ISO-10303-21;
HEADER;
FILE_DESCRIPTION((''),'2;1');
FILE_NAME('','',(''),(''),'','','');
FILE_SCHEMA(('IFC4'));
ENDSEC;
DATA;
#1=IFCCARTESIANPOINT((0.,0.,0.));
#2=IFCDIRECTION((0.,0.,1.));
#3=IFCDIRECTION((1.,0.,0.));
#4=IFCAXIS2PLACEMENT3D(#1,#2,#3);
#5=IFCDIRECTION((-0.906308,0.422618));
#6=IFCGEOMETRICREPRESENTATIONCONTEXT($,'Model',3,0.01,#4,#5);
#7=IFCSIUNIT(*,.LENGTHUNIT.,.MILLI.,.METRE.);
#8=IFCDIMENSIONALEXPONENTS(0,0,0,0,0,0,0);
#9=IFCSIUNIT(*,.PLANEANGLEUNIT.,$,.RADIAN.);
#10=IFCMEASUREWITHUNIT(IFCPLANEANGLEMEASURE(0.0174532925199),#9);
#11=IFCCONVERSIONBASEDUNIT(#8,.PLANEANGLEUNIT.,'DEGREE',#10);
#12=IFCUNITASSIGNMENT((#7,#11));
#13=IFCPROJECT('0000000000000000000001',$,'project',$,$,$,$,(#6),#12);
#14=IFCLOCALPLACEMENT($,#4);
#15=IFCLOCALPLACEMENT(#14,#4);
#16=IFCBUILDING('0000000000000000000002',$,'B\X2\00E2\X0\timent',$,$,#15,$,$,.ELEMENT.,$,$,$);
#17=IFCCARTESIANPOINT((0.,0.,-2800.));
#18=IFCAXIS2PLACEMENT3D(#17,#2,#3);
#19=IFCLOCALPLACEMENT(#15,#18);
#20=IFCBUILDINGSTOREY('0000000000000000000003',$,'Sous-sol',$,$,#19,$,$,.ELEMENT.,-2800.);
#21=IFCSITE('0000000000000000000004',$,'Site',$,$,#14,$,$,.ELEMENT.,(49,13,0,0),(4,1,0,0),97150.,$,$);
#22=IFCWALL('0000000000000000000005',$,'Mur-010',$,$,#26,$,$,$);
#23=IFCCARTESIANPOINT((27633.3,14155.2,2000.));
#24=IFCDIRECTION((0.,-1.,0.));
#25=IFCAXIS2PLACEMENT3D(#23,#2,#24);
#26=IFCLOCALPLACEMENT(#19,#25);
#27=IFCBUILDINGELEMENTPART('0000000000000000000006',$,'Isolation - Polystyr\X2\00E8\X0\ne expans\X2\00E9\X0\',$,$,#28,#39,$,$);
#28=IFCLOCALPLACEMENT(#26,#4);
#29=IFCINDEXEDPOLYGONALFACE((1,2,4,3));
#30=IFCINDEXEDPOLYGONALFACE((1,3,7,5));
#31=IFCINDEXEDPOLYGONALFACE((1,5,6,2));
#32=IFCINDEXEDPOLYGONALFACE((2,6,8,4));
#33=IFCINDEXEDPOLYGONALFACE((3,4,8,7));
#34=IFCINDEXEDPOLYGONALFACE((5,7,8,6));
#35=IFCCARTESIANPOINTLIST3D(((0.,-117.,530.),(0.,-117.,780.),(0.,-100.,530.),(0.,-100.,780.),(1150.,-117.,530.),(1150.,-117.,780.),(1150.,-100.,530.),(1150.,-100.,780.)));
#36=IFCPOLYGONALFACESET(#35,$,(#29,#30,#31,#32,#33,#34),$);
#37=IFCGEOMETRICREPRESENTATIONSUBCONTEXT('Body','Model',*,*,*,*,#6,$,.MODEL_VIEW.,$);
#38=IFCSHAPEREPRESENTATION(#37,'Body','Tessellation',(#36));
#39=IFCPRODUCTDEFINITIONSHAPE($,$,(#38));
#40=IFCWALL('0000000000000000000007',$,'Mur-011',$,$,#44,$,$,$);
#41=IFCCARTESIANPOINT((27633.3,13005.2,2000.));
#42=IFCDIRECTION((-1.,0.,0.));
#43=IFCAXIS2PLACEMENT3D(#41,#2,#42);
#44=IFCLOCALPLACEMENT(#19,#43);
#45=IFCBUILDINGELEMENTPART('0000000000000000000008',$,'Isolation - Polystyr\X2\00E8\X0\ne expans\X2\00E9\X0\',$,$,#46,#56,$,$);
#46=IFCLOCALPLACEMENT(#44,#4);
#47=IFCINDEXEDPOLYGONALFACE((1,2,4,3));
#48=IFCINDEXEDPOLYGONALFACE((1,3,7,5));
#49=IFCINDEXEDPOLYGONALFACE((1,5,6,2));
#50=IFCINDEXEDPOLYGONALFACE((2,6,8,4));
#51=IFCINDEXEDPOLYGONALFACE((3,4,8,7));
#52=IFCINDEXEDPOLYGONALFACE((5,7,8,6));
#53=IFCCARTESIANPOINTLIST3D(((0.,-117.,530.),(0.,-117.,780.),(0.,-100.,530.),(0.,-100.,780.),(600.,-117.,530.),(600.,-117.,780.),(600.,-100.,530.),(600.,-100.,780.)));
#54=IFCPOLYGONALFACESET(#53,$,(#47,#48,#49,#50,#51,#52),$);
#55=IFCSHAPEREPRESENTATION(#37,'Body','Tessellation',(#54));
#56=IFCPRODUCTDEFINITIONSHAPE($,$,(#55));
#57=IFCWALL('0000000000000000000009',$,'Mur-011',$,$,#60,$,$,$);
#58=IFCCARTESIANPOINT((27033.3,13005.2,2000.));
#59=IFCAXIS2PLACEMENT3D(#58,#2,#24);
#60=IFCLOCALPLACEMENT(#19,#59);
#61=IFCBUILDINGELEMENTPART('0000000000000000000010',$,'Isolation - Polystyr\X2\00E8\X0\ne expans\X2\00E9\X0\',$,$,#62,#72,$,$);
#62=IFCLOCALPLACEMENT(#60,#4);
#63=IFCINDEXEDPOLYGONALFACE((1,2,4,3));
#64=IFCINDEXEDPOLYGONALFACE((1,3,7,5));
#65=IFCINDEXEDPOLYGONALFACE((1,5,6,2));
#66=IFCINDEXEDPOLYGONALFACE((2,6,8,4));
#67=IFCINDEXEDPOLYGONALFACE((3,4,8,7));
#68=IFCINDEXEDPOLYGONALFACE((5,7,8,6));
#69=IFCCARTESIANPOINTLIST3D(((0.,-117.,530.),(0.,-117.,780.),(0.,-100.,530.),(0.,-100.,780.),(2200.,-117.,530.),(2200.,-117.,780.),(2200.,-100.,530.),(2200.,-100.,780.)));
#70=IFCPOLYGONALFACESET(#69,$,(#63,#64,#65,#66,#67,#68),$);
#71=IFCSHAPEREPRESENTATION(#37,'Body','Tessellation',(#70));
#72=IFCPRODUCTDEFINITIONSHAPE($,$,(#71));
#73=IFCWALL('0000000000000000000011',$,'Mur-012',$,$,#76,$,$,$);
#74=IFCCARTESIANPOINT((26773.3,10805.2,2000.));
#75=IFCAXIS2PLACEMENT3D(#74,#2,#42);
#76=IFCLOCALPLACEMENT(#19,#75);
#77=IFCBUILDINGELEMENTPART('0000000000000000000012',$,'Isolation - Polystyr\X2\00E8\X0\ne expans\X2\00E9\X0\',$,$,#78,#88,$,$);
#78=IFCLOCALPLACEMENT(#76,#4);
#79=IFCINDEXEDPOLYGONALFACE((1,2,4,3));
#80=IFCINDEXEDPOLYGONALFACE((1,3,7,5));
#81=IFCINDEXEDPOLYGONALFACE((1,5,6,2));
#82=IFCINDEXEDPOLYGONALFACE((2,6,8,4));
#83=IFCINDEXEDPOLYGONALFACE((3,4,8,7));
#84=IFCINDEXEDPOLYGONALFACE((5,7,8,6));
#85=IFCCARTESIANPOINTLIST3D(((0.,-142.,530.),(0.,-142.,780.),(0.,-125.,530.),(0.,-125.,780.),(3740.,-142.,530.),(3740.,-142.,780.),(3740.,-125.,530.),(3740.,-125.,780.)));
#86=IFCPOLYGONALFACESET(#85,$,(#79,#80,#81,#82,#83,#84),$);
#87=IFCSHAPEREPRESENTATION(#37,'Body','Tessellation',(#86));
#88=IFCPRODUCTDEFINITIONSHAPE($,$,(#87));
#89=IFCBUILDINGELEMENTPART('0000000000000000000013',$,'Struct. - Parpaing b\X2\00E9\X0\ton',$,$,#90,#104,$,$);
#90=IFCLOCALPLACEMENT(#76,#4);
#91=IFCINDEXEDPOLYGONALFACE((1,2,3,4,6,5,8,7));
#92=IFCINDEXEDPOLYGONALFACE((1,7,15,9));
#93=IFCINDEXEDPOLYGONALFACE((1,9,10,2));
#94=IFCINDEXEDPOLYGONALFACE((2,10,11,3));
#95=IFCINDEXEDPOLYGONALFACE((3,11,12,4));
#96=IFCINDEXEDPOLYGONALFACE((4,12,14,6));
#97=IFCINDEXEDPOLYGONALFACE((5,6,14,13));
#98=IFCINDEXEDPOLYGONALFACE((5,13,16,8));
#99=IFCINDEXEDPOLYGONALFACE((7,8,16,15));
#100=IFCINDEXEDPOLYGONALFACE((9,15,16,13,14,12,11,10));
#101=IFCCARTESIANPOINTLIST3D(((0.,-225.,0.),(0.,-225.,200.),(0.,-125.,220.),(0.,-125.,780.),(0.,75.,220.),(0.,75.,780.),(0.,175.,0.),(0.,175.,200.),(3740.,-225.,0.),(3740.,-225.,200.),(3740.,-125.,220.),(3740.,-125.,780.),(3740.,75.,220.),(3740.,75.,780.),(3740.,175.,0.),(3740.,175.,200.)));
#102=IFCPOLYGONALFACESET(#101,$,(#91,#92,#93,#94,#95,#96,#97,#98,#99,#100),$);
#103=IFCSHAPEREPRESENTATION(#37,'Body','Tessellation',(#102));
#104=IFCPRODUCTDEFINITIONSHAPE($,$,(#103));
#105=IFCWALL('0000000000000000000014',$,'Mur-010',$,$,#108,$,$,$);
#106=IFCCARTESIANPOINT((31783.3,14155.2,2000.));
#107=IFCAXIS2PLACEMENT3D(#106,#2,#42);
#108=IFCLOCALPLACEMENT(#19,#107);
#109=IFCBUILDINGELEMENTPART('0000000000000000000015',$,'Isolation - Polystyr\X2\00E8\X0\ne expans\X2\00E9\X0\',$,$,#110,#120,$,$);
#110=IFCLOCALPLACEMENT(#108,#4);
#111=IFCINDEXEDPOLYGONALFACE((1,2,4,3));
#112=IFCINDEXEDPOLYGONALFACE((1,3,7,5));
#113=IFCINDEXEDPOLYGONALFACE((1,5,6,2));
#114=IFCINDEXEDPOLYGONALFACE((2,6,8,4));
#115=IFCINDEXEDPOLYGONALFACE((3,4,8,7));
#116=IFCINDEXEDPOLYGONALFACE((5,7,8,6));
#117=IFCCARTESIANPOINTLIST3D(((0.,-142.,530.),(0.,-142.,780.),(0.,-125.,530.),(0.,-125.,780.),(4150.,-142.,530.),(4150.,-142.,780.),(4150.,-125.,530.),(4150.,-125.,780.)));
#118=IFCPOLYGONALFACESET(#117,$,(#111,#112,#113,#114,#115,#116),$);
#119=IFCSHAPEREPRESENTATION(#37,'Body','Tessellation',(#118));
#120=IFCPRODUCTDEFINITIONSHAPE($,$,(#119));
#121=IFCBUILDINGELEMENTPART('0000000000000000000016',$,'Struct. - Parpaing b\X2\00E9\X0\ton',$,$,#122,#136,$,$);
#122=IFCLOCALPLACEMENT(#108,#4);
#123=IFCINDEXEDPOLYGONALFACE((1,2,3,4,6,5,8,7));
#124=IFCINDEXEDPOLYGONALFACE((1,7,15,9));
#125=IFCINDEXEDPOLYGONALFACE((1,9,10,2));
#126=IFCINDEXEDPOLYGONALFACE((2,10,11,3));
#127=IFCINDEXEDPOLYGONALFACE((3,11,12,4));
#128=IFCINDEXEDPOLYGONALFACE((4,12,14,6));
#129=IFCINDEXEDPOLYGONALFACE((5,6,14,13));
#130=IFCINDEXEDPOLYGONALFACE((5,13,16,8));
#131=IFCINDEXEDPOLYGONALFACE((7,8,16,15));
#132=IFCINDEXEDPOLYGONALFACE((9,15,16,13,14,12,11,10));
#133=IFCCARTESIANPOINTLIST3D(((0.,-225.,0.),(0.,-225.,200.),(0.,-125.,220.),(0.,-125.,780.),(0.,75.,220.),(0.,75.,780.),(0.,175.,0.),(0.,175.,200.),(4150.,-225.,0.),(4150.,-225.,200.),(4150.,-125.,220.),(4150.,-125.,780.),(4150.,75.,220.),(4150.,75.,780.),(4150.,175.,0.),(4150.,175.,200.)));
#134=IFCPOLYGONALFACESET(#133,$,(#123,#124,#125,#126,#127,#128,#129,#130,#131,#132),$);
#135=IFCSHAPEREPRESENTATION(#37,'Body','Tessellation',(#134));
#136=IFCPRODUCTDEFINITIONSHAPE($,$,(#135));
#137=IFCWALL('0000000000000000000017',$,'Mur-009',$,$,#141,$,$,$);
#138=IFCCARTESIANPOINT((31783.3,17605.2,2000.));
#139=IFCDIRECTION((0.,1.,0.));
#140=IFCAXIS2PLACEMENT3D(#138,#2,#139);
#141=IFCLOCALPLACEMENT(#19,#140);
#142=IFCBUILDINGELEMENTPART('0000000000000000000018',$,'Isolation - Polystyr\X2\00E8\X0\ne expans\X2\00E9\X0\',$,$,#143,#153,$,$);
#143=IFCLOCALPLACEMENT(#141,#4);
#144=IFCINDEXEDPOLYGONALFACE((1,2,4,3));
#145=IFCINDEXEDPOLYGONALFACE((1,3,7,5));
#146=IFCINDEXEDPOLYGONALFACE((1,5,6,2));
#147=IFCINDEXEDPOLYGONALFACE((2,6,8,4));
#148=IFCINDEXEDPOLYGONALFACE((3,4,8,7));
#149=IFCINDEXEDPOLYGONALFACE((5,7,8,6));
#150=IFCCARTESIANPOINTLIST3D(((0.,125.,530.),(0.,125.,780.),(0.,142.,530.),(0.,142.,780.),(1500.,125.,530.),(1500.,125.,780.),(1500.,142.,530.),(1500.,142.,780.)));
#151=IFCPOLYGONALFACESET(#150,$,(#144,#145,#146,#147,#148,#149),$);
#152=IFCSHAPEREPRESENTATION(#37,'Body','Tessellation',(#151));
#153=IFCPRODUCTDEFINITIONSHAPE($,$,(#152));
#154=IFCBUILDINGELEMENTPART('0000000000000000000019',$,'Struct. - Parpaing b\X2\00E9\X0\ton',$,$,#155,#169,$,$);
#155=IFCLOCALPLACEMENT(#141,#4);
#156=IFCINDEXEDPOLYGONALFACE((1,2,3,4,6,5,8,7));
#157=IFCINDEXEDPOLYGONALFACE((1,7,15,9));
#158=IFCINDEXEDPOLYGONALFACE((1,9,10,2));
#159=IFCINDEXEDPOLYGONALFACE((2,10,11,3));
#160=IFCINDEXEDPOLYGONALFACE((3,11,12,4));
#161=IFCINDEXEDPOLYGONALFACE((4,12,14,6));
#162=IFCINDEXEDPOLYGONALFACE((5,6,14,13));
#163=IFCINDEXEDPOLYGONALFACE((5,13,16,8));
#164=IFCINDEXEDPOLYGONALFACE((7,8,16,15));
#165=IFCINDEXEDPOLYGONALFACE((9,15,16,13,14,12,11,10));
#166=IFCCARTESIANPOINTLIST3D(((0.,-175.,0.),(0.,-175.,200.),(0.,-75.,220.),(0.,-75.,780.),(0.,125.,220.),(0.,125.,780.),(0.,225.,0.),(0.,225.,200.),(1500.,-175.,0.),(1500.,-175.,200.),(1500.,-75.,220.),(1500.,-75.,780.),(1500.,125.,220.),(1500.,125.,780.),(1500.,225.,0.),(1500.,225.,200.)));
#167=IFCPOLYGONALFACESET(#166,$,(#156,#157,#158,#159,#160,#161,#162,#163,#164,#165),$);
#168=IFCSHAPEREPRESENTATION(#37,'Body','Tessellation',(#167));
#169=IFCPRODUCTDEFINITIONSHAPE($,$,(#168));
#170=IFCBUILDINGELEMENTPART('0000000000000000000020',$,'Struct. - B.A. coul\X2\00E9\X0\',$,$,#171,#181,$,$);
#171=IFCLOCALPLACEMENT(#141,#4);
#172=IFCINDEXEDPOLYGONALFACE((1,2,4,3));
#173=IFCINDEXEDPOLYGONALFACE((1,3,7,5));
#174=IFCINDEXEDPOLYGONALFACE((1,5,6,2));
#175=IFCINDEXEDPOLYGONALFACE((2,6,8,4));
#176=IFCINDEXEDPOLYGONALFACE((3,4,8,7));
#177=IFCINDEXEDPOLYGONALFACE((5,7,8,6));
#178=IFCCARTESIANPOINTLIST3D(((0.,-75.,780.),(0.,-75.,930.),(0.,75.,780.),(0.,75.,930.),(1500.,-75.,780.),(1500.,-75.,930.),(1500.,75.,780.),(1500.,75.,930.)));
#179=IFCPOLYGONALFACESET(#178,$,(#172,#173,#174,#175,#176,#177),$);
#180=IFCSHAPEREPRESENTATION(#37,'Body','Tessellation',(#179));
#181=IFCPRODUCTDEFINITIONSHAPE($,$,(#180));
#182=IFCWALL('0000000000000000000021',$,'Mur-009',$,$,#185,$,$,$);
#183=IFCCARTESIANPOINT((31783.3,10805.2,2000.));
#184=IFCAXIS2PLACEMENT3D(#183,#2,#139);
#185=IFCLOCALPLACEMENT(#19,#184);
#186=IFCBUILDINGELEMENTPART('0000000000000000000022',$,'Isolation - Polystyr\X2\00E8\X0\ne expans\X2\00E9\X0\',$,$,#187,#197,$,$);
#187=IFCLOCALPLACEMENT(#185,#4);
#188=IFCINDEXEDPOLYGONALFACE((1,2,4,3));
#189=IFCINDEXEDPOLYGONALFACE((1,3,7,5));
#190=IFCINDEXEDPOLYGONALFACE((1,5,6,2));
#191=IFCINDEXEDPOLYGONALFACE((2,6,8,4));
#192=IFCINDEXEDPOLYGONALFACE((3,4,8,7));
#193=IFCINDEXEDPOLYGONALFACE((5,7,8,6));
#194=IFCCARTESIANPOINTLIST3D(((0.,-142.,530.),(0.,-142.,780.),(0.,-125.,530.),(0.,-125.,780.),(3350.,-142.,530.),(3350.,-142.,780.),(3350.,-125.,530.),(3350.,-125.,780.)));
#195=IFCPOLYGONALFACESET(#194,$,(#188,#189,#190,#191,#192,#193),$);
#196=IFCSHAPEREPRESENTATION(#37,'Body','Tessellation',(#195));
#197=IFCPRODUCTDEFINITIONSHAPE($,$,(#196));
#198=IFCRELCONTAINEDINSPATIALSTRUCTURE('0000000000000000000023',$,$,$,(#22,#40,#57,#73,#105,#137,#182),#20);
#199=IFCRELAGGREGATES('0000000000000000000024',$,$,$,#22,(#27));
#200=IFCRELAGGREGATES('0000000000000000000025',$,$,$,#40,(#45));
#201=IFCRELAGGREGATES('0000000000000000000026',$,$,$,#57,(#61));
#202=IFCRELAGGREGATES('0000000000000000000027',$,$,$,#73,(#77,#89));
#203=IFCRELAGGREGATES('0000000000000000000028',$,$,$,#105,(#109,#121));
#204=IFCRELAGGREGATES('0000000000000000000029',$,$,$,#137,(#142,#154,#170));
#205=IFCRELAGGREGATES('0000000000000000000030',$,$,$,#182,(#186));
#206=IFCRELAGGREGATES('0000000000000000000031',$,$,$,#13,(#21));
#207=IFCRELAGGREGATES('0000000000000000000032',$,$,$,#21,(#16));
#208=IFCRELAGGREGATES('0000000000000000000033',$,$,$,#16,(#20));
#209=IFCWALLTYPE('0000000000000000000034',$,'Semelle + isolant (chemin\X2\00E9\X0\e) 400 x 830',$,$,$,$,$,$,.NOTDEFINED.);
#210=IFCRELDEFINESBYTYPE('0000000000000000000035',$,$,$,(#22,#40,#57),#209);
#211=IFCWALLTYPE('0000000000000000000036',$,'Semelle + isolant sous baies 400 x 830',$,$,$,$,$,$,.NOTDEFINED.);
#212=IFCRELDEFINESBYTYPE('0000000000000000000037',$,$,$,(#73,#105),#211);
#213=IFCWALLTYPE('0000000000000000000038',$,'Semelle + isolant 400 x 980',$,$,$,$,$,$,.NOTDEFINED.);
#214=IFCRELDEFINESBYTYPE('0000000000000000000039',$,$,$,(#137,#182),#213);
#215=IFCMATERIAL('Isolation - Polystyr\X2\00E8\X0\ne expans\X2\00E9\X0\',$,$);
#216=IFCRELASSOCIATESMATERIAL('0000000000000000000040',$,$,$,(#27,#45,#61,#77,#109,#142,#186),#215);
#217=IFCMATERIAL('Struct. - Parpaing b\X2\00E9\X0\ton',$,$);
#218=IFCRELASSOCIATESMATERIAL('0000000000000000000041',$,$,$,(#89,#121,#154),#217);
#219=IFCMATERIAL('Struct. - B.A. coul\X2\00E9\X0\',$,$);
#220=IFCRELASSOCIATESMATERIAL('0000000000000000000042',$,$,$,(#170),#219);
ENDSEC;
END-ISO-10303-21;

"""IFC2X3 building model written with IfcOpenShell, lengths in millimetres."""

from ifc_helpers import new_model, entity, si_unit, converted_unit, direction, frame, origin_with_axes, place, context, subcontext, project, spatial, polyline, outline, extrude, material, type_object, element, aggregate, save


model = new_model("IFC2X3")

# Units and contexts
model_context = context("Model", 3, precision=0.01, world=origin_with_axes(), true_north=direction((-0.906308, 0.422618)))
body_context = subcontext(model_context, "Body", "Model", "MODEL_VIEW")
ifc_project = project(units=[si_unit("LENGTHUNIT", "METRE", prefix="MILLI"), converted_unit("PLANEANGLEUNIT", "DEGREE", entity("IfcPlaneAngleMeasure", 0.0174532925199), si_unit("PLANEANGLEUNIT", "RADIAN"), dimensions=[0, 0, 0, 0, 0, 0, 0])], contexts=[model_context])

# Site, building, storey
site_placement = place(None, origin_with_axes())
site = spatial("IfcSite", under=ifc_project, at=site_placement, Name="Site", CompositionType="ELEMENT", RefLatitude=(49, 13, 0, 0), RefLongitude=(4, 1, 0, 0), RefElevation=97150.0)
building_placement = place(site_placement, origin_with_axes())
building = spatial("IfcBuilding", under=site, at=building_placement, Name="Bâtiment", CompositionType="ELEMENT")
storey_placement = place(building_placement, frame((0.0, 0.0, -2800.0), z_axis=(0.0, 0.0, 1.0), x_axis=(1.0, 0.0, 0.0)))
storey = spatial("IfcBuildingStorey", under=building, at=storey_placement, Name="Sous-sol", CompositionType="ELEMENT", Elevation=-2800.0)

# Walls, building element parts
ifc_material_1 = material(Name="Struct. - Parpaing béton")
wall_type_1 = type_object("IfcWallType", Name="Semelle + isolant (cheminée) 400 x 830", PredefinedType="NOTDEFINED")
wall_1_placement = place(storey_placement, frame((27633.3, 14155.2, 2000.0), z_axis=(0.0, 0.0, 1.0), x_axis=(0.0, -1.0, 0.0)))
wall_1 = element("IfcWall", 1, at=wall_1_placement, inside=storey, type_object=wall_type_1, Name="Mur-010")
ifc_material_2 = material(Name="Isolation - Polystyrène expansé")
building_element_part_1_placement = place(wall_1_placement, origin_with_axes())
building_element_part_1 = element("IfcBuildingElementPart", 2, at=building_element_part_1_placement, material=ifc_material_2, Name="Isolation - Polystyrène expansé", context=body_context, shape_type="SweptSolid", body=[
    extrude(outline(polyline([(100.0, 780.0), (100.0, 530.0), (117.0, 530.0), (117.0, 780.0), (100.0, 780.0)])), frame((0.0, 0.0, 0.0), z_axis=(-1.0, 0.0, 0.0), x_axis=(0.0, -1.0, 0.0)), (0.0, 0.0, -1.0), 1150.0),
])
aggregate(wall_1, [building_element_part_1])
wall_2_placement = place(storey_placement, frame((27633.3, 13005.2, 2000.0), z_axis=(0.0, 0.0, 1.0), x_axis=(-1.0, 0.0, 0.0)))
wall_2 = element("IfcWall", 3, at=wall_2_placement, inside=storey, type_object=wall_type_1, Name="Mur-011")
building_element_part_2_placement = place(wall_2_placement, origin_with_axes())
building_element_part_2 = element("IfcBuildingElementPart", 4, at=building_element_part_2_placement, material=ifc_material_2, Name="Isolation - Polystyrène expansé", context=body_context, shape_type="SweptSolid", body=[
    extrude(outline(polyline([(100.0, 780.0), (100.0, 530.0), (117.0, 530.0), (117.0, 780.0), (100.0, 780.0)])), frame((0.0, 0.0, 0.0), z_axis=(-1.0, 0.0, 0.0), x_axis=(0.0, -1.0, 0.0)), (0.0, 0.0, -1.0), 600.0),
])
aggregate(wall_2, [building_element_part_2])
wall_3_placement = place(storey_placement, frame((27033.3, 13005.2, 2000.0), z_axis=(0.0, 0.0, 1.0), x_axis=(0.0, -1.0, 0.0)))
wall_3 = element("IfcWall", 5, at=wall_3_placement, inside=storey, type_object=wall_type_1, Name="Mur-011")
building_element_part_3_placement = place(wall_3_placement, origin_with_axes())
building_element_part_3 = element("IfcBuildingElementPart", 6, at=building_element_part_3_placement, material=ifc_material_2, Name="Isolation - Polystyrène expansé", context=body_context, shape_type="SweptSolid", body=[
    extrude(outline(polyline([(100.0, 780.0), (100.0, 530.0), (117.0, 530.0), (117.0, 780.0), (100.0, 780.0)])), frame((0.0, 0.0, 0.0), z_axis=(-1.0, 0.0, 0.0), x_axis=(0.0, -1.0, 0.0)), (0.0, 0.0, -1.0), 2200.0),
])
aggregate(wall_3, [building_element_part_3])
wall_type_2 = type_object("IfcWallType", Name="Semelle + isolant sous baies 400 x 830", PredefinedType="NOTDEFINED")
wall_4_placement = place(storey_placement, frame((26773.3, 10805.2, 2000.0), z_axis=(0.0, 0.0, 1.0), x_axis=(-1.0, 0.0, 0.0)))
wall_4 = element("IfcWall", 7, at=wall_4_placement, inside=storey, type_object=wall_type_2, Name="Mur-012")
building_element_part_4_placement = place(wall_4_placement, origin_with_axes())
building_element_part_4 = element("IfcBuildingElementPart", 8, at=building_element_part_4_placement, material=ifc_material_2, Name="Isolation - Polystyrène expansé", context=body_context, shape_type="SweptSolid", body=[
    extrude(outline(polyline([(125.0, 780.0), (125.0, 530.0), (142.0, 530.0), (142.0, 780.0), (125.0, 780.0)])), frame((0.0, 0.0, 0.0), z_axis=(-1.0, 0.0, 0.0), x_axis=(0.0, -1.0, 0.0)), (0.0, 0.0, -1.0), 3740.0),
])
building_element_part_5_placement = place(wall_4_placement, origin_with_axes())
building_element_part_5 = element("IfcBuildingElementPart", 9, at=building_element_part_5_placement, material=ifc_material_1, Name="Struct. - Parpaing béton", context=body_context, shape_type="SweptSolid", body=[
    extrude(outline(polyline([(-175.0, 200.0), (-175.0, 0.0), (225.0, 0.0), (225.0, 200.0), (125.0, 220.0), (125.0, 780.0), (-75.0, 780.0), (-75.0, 220.0), (-175.0, 200.0)])), frame((0.0, 0.0, 0.0), z_axis=(-1.0, 0.0, 0.0), x_axis=(0.0, -1.0, 0.0)), (0.0, 0.0, -1.0), 3740.0),
])
aggregate(wall_4, [building_element_part_4, building_element_part_5])
wall_5_placement = place(storey_placement, frame((31783.3, 14155.2, 2000.0), z_axis=(0.0, 0.0, 1.0), x_axis=(-1.0, 0.0, 0.0)))
wall_5 = element("IfcWall", 10, at=wall_5_placement, inside=storey, type_object=wall_type_2, Name="Mur-010")
building_element_part_6_placement = place(wall_5_placement, origin_with_axes())
building_element_part_6 = element("IfcBuildingElementPart", 11, at=building_element_part_6_placement, material=ifc_material_2, Name="Isolation - Polystyrène expansé", context=body_context, shape_type="SweptSolid", body=[
    extrude(outline(polyline([(125.0, 780.0), (125.0, 530.0), (142.0, 530.0), (142.0, 780.0), (125.0, 780.0)])), frame((0.0, 0.0, 0.0), z_axis=(-1.0, 0.0, 0.0), x_axis=(0.0, -1.0, 0.0)), (0.0, 0.0, -1.0), 4150.0),
])
building_element_part_7_placement = place(wall_5_placement, origin_with_axes())
building_element_part_7 = element("IfcBuildingElementPart", 12, at=building_element_part_7_placement, material=ifc_material_1, Name="Struct. - Parpaing béton", context=body_context, shape_type="SweptSolid", body=[
    extrude(outline(polyline([(-175.0, 200.0), (-175.0, 0.0), (225.0, 0.0), (225.0, 200.0), (125.0, 220.0), (125.0, 780.0), (-75.0, 780.0), (-75.0, 220.0), (-175.0, 200.0)])), frame((0.0, 0.0, 0.0), z_axis=(-1.0, 0.0, 0.0), x_axis=(0.0, -1.0, 0.0)), (0.0, 0.0, -1.0), 4150.0),
])
aggregate(wall_5, [building_element_part_6, building_element_part_7])
wall_type_3 = type_object("IfcWallType", Name="Semelle + isolant 400 x 980", PredefinedType="NOTDEFINED")
wall_6_placement = place(storey_placement, frame((31783.3, 17605.2, 2000.0), z_axis=(0.0, 0.0, 1.0), x_axis=(0.0, 1.0, 0.0)))
wall_6 = element("IfcWall", 13, at=wall_6_placement, inside=storey, type_object=wall_type_3, Name="Mur-009")
building_element_part_8_placement = place(wall_6_placement, origin_with_axes())
building_element_part_8 = element("IfcBuildingElementPart", 14, at=building_element_part_8_placement, material=ifc_material_2, Name="Isolation - Polystyrène expansé", context=body_context, shape_type="SweptSolid", body=[
    extrude(outline(polyline([(125.0, 780.0), (125.0, 530.0), (142.0, 530.0), (142.0, 780.0), (125.0, 780.0)])), frame((0.0, 0.0, 0.0), z_axis=(1.0, 0.0, 0.0), x_axis=(0.0, 1.0, 0.0)), (0.0, 0.0, 1.0), 1500.0),
])
building_element_part_9_placement = place(wall_6_placement, origin_with_axes())
building_element_part_9 = element("IfcBuildingElementPart", 15, at=building_element_part_9_placement, material=ifc_material_1, Name="Struct. - Parpaing béton", context=body_context, shape_type="SweptSolid", body=[
    extrude(outline(polyline([(-75.0, 220.0), (-175.0, 200.0), (-175.0, 0.0), (225.0, 0.0), (225.0, 200.0), (125.0, 220.0), (125.0, 780.0), (-75.0, 780.0), (-75.0, 220.0)])), frame((0.0, 0.0, 0.0), z_axis=(1.0, 0.0, 0.0), x_axis=(0.0, 1.0, 0.0)), (0.0, 0.0, 1.0), 1500.0),
])
ifc_material_3 = material(Name="Struct. - B.A. coulé")
building_element_part_10_placement = place(wall_6_placement, origin_with_axes())
building_element_part_10 = element("IfcBuildingElementPart", 16, at=building_element_part_10_placement, material=ifc_material_3, Name="Struct. - B.A. coulé", context=body_context, shape_type="SweptSolid", body=[
    extrude(outline(polyline([(75.0, 780.0), (75.0, 930.0), (-75.0, 930.0), (-75.0, 780.0), (75.0, 780.0)])), frame((0.0, 0.0, 0.0), z_axis=(1.0, 0.0, 0.0), x_axis=(0.0, 1.0, 0.0)), (0.0, 0.0, 1.0), 1500.0),
])
aggregate(wall_6, [building_element_part_8, building_element_part_9, building_element_part_10])

# Wall, building element part
wall_7_placement = place(storey_placement, frame((31783.3, 10805.2, 2000.0), z_axis=(0.0, 0.0, 1.0), x_axis=(0.0, 1.0, 0.0)))
wall_7 = element("IfcWall", 17, at=wall_7_placement, inside=storey, type_object=wall_type_3, Name="Mur-009")
building_element_part_11_placement = place(wall_7_placement, origin_with_axes())
building_element_part_11 = element("IfcBuildingElementPart", 18, at=building_element_part_11_placement, material=ifc_material_2, Name="Isolation - Polystyrène expansé", context=body_context, shape_type="SweptSolid", body=[
    extrude(outline(polyline([(125.0, 780.0), (125.0, 530.0), (142.0, 530.0), (142.0, 780.0), (125.0, 780.0)])), frame((0.0, 0.0, 0.0), z_axis=(-1.0, 0.0, 0.0), x_axis=(0.0, -1.0, 0.0)), (0.0, 0.0, -1.0), 3350.0),
])
aggregate(wall_7, [building_element_part_11])

save(model, "model.ifc")
